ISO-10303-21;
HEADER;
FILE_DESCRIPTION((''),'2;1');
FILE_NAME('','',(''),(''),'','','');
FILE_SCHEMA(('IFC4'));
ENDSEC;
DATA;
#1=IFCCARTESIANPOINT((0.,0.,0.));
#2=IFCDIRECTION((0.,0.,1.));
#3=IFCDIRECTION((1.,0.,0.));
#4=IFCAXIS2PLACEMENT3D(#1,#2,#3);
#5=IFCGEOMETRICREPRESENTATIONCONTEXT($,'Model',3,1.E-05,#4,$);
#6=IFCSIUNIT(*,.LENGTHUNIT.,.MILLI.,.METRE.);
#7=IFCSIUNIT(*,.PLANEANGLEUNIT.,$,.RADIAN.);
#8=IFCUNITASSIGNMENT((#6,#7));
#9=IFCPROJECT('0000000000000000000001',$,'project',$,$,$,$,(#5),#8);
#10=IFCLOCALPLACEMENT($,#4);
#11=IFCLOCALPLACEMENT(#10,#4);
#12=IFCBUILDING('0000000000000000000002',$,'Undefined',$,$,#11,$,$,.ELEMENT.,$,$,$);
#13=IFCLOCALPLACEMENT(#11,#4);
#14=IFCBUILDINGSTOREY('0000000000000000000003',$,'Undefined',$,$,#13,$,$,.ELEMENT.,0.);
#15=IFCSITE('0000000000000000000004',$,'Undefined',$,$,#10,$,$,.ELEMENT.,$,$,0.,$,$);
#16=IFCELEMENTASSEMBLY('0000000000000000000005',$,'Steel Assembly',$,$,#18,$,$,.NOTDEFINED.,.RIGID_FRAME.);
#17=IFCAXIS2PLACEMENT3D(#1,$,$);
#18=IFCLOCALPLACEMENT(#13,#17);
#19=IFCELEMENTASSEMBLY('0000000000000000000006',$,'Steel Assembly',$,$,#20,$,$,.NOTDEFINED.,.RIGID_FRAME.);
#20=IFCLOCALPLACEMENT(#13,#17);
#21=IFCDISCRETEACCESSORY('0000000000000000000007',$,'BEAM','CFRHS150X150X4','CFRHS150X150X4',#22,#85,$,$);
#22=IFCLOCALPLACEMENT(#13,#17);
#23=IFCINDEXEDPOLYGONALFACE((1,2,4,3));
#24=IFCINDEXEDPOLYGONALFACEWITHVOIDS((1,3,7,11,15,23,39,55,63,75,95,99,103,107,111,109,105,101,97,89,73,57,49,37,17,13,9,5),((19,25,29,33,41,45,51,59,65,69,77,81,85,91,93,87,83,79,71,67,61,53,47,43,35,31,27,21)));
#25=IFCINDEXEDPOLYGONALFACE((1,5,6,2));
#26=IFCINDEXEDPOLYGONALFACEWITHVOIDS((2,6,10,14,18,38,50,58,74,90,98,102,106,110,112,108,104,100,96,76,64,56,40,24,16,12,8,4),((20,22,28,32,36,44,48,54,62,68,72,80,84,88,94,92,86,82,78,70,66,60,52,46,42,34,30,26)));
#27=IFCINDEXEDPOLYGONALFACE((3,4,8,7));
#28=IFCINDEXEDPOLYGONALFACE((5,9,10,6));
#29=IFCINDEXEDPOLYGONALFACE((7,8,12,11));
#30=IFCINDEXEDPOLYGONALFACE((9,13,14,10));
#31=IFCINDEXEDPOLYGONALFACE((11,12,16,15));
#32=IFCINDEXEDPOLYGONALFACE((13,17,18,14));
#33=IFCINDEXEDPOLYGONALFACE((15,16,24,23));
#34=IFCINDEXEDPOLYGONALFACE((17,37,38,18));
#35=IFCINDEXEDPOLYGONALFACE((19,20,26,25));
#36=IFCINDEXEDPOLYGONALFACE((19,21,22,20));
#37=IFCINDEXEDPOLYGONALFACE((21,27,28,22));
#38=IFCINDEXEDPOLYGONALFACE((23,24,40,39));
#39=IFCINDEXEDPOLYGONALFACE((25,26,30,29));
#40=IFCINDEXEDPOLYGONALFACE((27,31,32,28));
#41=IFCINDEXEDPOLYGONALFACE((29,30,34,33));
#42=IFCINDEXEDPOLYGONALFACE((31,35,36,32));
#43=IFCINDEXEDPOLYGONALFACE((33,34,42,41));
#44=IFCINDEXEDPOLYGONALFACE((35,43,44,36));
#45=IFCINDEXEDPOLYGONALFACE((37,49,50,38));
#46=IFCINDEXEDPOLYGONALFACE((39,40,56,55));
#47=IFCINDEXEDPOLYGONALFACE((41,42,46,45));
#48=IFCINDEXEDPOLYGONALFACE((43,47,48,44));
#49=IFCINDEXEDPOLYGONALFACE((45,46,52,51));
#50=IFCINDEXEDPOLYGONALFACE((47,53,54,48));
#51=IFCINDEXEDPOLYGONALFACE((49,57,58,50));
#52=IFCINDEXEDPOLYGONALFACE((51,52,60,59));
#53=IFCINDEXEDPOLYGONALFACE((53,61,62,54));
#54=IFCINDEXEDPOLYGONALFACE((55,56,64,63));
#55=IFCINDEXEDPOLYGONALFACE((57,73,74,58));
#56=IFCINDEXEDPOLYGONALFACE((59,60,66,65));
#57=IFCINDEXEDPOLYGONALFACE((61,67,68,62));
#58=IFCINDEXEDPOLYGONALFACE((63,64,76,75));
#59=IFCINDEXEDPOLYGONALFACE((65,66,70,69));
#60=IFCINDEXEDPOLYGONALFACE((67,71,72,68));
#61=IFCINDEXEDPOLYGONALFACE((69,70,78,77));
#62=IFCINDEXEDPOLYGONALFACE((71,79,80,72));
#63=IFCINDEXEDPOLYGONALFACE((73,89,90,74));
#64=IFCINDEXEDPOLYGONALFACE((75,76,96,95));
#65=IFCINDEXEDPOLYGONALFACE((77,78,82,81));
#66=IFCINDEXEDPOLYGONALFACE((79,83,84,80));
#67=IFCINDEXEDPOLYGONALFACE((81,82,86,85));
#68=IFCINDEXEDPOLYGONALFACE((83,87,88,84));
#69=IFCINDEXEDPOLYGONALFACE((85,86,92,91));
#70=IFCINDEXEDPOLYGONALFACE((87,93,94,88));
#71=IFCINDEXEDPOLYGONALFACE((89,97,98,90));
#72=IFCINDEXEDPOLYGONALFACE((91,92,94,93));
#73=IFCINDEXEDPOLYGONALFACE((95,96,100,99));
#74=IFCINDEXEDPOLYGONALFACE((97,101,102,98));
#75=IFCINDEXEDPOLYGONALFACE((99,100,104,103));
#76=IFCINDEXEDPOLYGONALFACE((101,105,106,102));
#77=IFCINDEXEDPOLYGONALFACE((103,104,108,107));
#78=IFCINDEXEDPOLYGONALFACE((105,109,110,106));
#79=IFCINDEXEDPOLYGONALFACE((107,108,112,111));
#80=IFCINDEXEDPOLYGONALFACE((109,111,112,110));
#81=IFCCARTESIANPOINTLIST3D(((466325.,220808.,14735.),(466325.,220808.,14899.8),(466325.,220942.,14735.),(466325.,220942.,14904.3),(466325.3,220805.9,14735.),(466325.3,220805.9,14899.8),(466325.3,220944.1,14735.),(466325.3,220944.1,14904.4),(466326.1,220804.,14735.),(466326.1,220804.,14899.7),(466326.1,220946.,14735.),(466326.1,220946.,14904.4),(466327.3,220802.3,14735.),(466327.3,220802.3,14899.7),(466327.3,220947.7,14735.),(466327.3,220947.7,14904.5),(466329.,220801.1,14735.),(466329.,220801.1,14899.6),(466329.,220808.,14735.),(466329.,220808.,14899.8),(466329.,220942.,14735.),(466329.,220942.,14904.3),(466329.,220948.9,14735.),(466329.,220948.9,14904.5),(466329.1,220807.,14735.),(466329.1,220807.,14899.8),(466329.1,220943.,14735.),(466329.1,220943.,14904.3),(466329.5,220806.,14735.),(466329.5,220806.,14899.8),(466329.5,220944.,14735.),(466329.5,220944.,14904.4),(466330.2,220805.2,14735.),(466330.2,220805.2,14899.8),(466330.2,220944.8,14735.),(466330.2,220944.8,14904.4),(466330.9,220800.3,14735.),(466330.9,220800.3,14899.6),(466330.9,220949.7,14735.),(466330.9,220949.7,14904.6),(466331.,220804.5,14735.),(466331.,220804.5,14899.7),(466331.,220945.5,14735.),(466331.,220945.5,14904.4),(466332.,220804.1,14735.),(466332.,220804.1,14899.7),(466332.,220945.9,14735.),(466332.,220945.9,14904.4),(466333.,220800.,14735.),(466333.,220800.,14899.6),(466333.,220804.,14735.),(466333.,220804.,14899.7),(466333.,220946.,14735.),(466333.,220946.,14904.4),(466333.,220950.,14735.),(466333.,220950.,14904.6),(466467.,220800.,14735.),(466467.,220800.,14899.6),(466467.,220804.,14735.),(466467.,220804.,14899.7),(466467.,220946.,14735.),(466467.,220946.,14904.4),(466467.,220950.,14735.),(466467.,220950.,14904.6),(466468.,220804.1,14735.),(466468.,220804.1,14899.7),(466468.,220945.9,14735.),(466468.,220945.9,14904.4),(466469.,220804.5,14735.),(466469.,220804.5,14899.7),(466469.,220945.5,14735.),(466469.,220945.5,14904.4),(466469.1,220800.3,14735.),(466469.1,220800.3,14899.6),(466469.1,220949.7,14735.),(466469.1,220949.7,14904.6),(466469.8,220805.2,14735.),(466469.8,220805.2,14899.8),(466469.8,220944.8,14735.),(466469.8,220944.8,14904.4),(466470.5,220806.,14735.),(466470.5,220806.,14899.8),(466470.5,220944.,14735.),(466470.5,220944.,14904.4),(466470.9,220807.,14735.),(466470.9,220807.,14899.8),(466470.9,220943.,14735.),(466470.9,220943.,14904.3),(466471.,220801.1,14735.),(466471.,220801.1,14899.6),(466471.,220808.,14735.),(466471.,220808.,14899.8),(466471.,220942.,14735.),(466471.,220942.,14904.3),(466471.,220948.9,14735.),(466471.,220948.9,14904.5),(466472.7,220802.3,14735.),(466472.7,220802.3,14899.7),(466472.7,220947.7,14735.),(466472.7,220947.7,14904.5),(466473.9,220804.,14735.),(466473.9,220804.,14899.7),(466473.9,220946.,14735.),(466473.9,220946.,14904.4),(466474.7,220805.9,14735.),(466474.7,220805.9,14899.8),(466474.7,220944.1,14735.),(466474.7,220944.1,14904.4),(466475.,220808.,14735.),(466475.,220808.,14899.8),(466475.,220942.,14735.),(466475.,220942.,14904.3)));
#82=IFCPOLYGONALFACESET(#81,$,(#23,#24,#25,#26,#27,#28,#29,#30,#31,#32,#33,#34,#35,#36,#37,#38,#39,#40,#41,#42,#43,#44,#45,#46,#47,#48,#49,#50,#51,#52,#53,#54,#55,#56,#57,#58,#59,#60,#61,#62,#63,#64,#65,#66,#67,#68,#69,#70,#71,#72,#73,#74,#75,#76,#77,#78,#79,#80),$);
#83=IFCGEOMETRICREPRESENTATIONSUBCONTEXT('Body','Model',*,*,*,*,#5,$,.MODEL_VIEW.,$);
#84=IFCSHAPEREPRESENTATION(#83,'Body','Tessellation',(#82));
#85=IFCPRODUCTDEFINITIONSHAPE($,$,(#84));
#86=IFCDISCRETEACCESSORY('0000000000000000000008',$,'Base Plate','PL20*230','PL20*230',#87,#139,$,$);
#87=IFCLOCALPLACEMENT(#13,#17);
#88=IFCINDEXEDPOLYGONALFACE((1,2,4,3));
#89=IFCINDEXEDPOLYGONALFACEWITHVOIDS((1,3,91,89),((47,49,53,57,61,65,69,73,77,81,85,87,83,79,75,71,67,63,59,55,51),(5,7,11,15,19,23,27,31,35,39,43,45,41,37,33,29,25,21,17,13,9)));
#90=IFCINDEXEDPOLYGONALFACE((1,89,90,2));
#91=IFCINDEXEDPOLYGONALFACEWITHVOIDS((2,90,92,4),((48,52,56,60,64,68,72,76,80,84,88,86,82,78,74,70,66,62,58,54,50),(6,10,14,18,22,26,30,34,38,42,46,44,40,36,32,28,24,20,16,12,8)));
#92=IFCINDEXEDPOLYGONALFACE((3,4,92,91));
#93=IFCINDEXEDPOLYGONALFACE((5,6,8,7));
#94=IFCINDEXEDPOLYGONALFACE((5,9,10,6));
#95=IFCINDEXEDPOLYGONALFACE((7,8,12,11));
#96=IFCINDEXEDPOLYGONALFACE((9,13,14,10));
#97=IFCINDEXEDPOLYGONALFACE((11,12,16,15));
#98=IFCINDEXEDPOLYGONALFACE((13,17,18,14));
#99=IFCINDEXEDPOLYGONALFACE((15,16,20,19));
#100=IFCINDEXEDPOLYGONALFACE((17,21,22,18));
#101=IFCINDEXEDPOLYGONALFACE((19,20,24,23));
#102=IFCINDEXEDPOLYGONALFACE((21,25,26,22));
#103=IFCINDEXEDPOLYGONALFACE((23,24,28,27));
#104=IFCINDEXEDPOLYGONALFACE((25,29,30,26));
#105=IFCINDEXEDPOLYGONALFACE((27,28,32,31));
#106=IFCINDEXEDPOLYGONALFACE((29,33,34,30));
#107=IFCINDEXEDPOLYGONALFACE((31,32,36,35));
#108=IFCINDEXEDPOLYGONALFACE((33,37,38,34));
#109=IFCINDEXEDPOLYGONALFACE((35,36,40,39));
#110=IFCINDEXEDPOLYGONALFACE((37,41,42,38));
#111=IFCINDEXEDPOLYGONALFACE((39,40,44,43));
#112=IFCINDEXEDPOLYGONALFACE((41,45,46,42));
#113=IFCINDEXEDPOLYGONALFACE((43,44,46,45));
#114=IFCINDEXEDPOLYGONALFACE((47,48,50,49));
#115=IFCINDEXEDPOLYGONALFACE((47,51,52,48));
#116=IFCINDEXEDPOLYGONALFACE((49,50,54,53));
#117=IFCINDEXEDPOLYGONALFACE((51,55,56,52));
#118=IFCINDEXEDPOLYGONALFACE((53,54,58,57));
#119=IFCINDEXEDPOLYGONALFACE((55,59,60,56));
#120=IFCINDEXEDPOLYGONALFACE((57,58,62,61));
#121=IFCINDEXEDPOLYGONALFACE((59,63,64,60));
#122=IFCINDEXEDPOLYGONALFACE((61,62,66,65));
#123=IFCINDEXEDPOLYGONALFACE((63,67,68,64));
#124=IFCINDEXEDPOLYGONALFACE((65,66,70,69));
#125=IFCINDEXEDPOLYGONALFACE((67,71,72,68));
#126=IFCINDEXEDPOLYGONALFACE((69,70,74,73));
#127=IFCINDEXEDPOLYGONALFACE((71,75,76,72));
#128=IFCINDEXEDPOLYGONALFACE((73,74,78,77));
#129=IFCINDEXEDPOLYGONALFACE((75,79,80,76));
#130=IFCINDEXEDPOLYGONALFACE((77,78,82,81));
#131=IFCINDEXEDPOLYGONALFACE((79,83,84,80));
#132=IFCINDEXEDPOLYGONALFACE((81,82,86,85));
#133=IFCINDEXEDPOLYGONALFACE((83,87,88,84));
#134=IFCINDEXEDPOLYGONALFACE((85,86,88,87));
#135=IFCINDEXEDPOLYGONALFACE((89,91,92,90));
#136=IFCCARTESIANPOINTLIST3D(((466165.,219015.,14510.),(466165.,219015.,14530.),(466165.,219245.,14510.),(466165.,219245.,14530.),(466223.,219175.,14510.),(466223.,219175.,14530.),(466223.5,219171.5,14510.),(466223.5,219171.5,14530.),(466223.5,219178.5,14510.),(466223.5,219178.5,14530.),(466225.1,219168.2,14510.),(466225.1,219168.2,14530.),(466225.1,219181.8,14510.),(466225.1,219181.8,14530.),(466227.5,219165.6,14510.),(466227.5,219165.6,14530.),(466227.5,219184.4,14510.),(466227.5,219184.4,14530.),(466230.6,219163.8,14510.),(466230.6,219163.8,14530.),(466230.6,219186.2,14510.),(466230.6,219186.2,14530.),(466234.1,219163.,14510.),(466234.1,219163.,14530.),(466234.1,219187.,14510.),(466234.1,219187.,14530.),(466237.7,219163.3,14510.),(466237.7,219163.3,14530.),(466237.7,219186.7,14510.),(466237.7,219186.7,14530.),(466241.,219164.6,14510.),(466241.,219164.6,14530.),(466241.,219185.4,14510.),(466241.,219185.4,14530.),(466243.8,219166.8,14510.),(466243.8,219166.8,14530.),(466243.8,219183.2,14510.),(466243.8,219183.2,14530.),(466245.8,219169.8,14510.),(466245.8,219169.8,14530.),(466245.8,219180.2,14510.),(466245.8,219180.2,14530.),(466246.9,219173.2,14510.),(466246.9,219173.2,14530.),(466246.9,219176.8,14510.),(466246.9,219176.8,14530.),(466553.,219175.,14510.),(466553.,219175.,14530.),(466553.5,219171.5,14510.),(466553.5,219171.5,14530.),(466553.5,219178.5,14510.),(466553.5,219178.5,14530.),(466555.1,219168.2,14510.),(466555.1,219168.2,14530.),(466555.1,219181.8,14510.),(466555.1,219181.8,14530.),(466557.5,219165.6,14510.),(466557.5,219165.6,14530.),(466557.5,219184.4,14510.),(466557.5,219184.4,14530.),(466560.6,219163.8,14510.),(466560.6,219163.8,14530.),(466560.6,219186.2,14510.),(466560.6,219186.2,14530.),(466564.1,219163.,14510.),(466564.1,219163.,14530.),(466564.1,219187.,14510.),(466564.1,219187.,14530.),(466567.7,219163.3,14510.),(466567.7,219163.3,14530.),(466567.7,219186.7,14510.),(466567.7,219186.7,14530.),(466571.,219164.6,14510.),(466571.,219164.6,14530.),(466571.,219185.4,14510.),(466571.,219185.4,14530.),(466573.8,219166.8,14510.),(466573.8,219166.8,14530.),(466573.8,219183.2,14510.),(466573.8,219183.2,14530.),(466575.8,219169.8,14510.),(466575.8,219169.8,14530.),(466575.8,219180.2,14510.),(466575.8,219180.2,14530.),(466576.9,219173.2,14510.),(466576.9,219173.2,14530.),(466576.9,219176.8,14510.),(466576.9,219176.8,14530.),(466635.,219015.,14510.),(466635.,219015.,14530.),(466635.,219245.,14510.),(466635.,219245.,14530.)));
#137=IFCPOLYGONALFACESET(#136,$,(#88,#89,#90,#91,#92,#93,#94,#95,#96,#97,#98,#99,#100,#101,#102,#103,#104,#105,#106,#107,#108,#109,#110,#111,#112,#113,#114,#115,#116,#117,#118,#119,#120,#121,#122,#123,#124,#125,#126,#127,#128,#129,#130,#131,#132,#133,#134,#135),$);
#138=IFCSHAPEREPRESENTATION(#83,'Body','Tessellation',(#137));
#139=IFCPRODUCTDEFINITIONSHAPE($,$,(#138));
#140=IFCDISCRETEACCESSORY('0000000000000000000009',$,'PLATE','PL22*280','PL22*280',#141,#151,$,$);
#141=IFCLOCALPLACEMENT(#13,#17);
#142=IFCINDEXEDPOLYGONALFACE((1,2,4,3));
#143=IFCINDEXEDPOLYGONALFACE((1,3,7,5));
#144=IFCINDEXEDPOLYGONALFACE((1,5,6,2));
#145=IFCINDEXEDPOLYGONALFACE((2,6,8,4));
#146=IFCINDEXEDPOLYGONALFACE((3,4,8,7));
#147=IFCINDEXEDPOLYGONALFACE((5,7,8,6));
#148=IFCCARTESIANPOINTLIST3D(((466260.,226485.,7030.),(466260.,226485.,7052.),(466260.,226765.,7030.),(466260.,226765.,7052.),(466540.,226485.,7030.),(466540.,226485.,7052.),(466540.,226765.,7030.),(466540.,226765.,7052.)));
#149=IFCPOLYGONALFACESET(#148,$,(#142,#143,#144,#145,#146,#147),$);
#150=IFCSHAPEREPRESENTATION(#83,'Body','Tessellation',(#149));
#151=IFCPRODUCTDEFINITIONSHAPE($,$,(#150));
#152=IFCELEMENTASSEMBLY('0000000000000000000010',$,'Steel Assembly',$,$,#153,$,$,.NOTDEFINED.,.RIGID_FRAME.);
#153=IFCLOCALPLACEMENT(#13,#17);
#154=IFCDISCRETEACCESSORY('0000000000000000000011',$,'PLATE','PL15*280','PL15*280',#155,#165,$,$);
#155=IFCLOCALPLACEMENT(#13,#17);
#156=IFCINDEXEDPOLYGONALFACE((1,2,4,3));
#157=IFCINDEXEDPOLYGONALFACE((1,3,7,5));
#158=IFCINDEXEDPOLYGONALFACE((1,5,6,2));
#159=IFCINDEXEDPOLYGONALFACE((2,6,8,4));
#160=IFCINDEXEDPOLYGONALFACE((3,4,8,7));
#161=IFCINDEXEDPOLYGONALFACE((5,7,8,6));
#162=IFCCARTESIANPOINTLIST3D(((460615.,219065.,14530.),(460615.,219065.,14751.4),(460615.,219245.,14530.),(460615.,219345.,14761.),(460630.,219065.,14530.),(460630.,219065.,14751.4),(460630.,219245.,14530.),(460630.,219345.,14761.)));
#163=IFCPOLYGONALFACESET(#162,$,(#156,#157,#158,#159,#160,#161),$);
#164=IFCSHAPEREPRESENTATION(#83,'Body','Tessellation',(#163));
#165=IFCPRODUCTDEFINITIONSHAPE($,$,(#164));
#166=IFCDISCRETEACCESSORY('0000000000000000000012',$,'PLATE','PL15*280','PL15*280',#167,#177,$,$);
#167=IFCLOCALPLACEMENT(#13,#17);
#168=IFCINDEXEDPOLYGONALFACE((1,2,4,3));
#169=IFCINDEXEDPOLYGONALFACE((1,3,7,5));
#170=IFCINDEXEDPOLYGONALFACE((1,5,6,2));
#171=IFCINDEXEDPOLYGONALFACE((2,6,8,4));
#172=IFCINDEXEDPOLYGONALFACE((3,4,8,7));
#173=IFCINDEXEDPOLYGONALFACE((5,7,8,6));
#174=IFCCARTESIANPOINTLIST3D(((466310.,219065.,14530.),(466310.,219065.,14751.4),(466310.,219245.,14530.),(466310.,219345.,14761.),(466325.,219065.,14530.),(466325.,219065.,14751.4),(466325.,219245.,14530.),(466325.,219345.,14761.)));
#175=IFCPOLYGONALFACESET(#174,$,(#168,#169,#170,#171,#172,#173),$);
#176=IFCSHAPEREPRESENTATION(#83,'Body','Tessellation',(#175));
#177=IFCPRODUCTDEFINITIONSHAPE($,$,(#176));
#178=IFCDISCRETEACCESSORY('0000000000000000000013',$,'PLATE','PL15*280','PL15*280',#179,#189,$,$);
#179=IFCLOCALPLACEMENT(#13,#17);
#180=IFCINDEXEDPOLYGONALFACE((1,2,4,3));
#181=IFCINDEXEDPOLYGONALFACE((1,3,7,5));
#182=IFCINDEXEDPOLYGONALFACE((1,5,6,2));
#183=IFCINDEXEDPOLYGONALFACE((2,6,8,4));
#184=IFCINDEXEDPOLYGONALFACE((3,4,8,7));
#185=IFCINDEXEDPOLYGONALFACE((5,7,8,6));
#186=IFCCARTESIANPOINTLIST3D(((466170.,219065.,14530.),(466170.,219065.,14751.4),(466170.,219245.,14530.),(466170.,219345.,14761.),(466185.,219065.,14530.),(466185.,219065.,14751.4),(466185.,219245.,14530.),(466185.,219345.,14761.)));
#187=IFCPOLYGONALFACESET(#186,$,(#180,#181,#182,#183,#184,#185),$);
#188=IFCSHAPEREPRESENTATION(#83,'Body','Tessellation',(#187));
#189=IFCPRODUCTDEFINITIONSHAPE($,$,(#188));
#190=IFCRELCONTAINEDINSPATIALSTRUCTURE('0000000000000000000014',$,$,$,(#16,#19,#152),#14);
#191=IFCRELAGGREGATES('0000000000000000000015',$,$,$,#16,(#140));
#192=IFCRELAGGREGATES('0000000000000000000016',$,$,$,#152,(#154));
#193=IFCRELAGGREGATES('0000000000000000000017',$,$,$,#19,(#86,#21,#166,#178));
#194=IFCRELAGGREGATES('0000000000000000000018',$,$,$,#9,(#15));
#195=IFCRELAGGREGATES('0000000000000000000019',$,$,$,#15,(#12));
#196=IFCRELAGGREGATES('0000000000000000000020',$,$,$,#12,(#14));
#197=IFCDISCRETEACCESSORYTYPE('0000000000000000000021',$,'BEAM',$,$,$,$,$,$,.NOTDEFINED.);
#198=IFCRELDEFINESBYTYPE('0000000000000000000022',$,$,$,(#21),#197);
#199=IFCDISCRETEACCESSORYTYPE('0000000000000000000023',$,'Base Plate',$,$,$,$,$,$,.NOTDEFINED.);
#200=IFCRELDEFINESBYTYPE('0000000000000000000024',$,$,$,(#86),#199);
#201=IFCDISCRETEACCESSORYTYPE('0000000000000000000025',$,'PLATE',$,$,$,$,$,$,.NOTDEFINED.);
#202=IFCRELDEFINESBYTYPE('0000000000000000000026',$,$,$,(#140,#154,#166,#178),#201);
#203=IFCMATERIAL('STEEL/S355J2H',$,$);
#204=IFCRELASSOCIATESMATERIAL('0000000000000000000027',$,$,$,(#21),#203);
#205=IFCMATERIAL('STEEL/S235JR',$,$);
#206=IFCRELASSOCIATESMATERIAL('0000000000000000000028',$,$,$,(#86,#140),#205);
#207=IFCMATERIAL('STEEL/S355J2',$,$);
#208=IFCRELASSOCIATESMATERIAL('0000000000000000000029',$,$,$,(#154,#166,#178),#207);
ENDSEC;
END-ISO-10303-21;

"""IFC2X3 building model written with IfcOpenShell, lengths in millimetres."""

from ifc_helpers import new_model, si_unit, frame, origin_with_axes, origin_2d_with_axis, place, context, subcontext, project, spatial, polyline, hollow_rectangle, circle, outline, extrude, boolean, clip, halfspace, material, type_object, element, aggregate, save


model = new_model("IFC2X3")

# Units and contexts
model_context = context("Model", 3, precision=1e-05, world=origin_with_axes())
body_context = subcontext(model_context, "Body", "Model", "MODEL_VIEW")
ifc_project = project(units=[si_unit("LENGTHUNIT", "METRE", prefix="MILLI"), si_unit("PLANEANGLEUNIT", "RADIAN")], contexts=[model_context])

# Site, building, storey
site_placement = place(None, origin_with_axes())
site = spatial("IfcSite", under=ifc_project, at=site_placement, Name="Undefined", CompositionType="ELEMENT", RefElevation=0.0)
building_placement = place(site_placement, origin_with_axes())
building = spatial("IfcBuilding", under=site, at=building_placement, Name="Undefined", CompositionType="ELEMENT")
storey_placement = place(building_placement, origin_with_axes())
storey = spatial("IfcBuildingStorey", under=building, at=storey_placement, Name="Undefined", CompositionType="ELEMENT", Elevation=0.0)

# Element assembly
ifc_material_1 = material(Name="STEEL/S235JR")
assembly_1_placement = place(storey_placement, origin_with_axes())
assembly_1 = element("IfcElementAssembly", 1, at=assembly_1_placement, inside=storey, Name="Steel Assembly", AssemblyPlace="NOTDEFINED", PredefinedType="RIGID_FRAME")

# Shared definitions
ifc_material_2 = material(Name="STEEL/S355J2H")

# Shared definitions
ifc_material_3 = material(Name="STEEL/S355J2")

# Element assembly, discrete accessories
assembly_2_placement = place(storey_placement, origin_with_axes())
assembly_2 = element("IfcElementAssembly", 2, at=assembly_2_placement, inside=storey, Name="Steel Assembly", AssemblyPlace="NOTDEFINED", PredefinedType="RIGID_FRAME")
discrete_accessory_type_1 = type_object("IfcDiscreteAccessoryType", Name="BEAM")
discrete_accessory_1_placement = place(assembly_2_placement, frame((466400.0, 220875.0, 14720.0), z_axis=(0.0, 0.0, 1.0), x_axis=(1.0, 0.0, 0.0)))
discrete_accessory_1 = element("IfcDiscreteAccessory", 3, at=discrete_accessory_1_placement, type_object=discrete_accessory_type_1, material=ifc_material_2, Name="BEAM", Description="CFRHS150X150X4", ObjectType="CFRHS150X150X4", context=body_context, shape_type="Clipping", body=[
    clip(extrude(hollow_rectangle(XDim=150.0, YDim=150.0, WallThickness=4.0, InnerFilletRadius=4.0, OuterFilletRadius=8.0, at=origin_2d_with_axis()), frame((0.0, 0.0, 184.6), z_axis=(0.0, 0.0, -1.0), x_axis=(0.0, -1.0, 0.0)), (0.0, 0.0, 1.0), 169.6), halfspace(frame((-1000.0, 2.7, 182.2), z_axis=(0.0, 0.033315, -0.999445), x_axis=(0.0, -0.999445, -0.033315)), True)),
])
discrete_accessory_type_2 = type_object("IfcDiscreteAccessoryType", Name="Base Plate")
discrete_accessory_2_placement = place(assembly_2_placement, frame((466165.0, 219245.0, 14520.0), z_axis=(0.0, 0.0, -1.0), x_axis=(1.0, 0.0, 0.0)))
discrete_accessory_2 = element("IfcDiscreteAccessory", 4, at=discrete_accessory_2_placement, type_object=discrete_accessory_type_2, material=ifc_material_1, Name="Base Plate", Description="PL20*230", ObjectType="PL20*230", context=body_context, shape_type="CSG", body=[
    boolean("DIFFERENCE", boolean("DIFFERENCE", extrude(outline(polyline([(0.0, 0.0), (470.0, 0.0), (470.0, 230.0), (0.0, 230.0), (0.0, 0.0)])), frame((0.0, 0.0, -10.0), z_axis=(0.0, 0.0, 1.0), x_axis=(1.0, 0.0, 0.0)), (0.0, 0.0, 1.0), 20.0), extrude(circle(Radius=12.0, at=origin_2d_with_axis()), frame((70.0, 70.0, -80.0), z_axis=(0.0, 0.0, 1.0), x_axis=(-1.0, 0.0, 0.0)), (0.0, 0.0, 1.0), 1160.0)), extrude(circle(Radius=12.0, at=origin_2d_with_axis()), frame((400.0, 70.0, -80.0), z_axis=(0.0, 0.0, 1.0), x_axis=(-1.0, 0.0, 0.0)), (0.0, 0.0, 1.0), 1160.0)),
])

# Discrete accessory
discrete_accessory_type_3 = type_object("IfcDiscreteAccessoryType", Name="PLATE")
discrete_accessory_3_placement = place(assembly_1_placement, frame((466400.0, 226485.0, 7041.0), z_axis=(0.0, 0.0, 1.0), x_axis=(0.0, 1.0, 0.0)))
discrete_accessory_3 = element("IfcDiscreteAccessory", 5, at=discrete_accessory_3_placement, type_object=discrete_accessory_type_3, material=ifc_material_1, Name="PLATE", Description="PL22*280", ObjectType="PL22*280", context=body_context, shape_type="SweptSolid", body=[
    extrude(outline(polyline([(280.0, 140.0), (280.0, -140.0), (0.0, -140.0), (0.0, 140.0), (280.0, 140.0)])), frame((0.0, 0.0, -11.0), z_axis=(0.0, 0.0, 1.0), x_axis=(1.0, 0.0, 0.0)), (0.0, 0.0, 1.0), 22.0),
])
aggregate(assembly_1, [discrete_accessory_3])

# Element assembly, discrete accessory
assembly_3_placement = place(storey_placement, origin_with_axes())
assembly_3 = element("IfcElementAssembly", 6, at=assembly_3_placement, inside=storey, Name="Steel Assembly", AssemblyPlace="NOTDEFINED", PredefinedType="RIGID_FRAME")
discrete_accessory_4_placement = place(assembly_3_placement, frame((460622.5, 219065.0, 14530.0), z_axis=(1.0, 0.0, 0.0), x_axis=(0.0, 1.0, 0.0)))
discrete_accessory_4 = element("IfcDiscreteAccessory", 7, at=discrete_accessory_4_placement, type_object=discrete_accessory_type_3, material=ifc_material_3, Name="PLATE", Description="PL15*280", ObjectType="PL15*280", context=body_context, shape_type="SweptSolid", body=[
    extrude(outline(polyline([(0.0, 0.0), (180.0, 0.0), (280.0, 231.0), (0.0, 221.4), (0.0, 0.0)])), frame((0.0, 0.0, -7.5), z_axis=(0.0, 0.0, 1.0), x_axis=(1.0, 0.0, 0.0)), (0.0, 0.0, 1.0), 15.0),
])
aggregate(assembly_3, [discrete_accessory_4])

# Discrete accessories
discrete_accessory_5_placement = place(assembly_2_placement, frame((466317.5, 219065.0, 14530.0), z_axis=(1.0, 0.0, 0.0), x_axis=(0.0, 1.0, 0.0)))
discrete_accessory_5 = element("IfcDiscreteAccessory", 8, at=discrete_accessory_5_placement, type_object=discrete_accessory_type_3, material=ifc_material_3, Name="PLATE", Description="PL15*280", ObjectType="PL15*280", context=body_context, shape_type="SweptSolid", body=[
    extrude(outline(polyline([(0.0, 0.0), (180.0, 0.0), (280.0, 231.0), (0.0, 221.4), (0.0, 0.0)])), frame((0.0, 0.0, -7.5), z_axis=(0.0, 0.0, 1.0), x_axis=(1.0, 0.0, 0.0)), (0.0, 0.0, 1.0), 15.0),
])
discrete_accessory_6_placement = place(assembly_2_placement, frame((466177.5, 219065.0, 14530.0), z_axis=(1.0, 0.0, 0.0), x_axis=(0.0, 1.0, 0.0)))
discrete_accessory_6 = element("IfcDiscreteAccessory", 9, at=discrete_accessory_6_placement, type_object=discrete_accessory_type_3, material=ifc_material_3, Name="PLATE", Description="PL15*280", ObjectType="PL15*280", context=body_context, shape_type="SweptSolid", body=[
    extrude(outline(polyline([(0.0, 0.0), (180.0, 0.0), (280.0, 231.0), (0.0, 221.4), (0.0, 0.0)])), frame((0.0, 0.0, -7.5), z_axis=(0.0, 0.0, 1.0), x_axis=(1.0, 0.0, 0.0)), (0.0, 0.0, 1.0), 15.0),
])
aggregate(assembly_2, [discrete_accessory_2, discrete_accessory_1, discrete_accessory_5, discrete_accessory_6])

save(model, "model.ifc")
